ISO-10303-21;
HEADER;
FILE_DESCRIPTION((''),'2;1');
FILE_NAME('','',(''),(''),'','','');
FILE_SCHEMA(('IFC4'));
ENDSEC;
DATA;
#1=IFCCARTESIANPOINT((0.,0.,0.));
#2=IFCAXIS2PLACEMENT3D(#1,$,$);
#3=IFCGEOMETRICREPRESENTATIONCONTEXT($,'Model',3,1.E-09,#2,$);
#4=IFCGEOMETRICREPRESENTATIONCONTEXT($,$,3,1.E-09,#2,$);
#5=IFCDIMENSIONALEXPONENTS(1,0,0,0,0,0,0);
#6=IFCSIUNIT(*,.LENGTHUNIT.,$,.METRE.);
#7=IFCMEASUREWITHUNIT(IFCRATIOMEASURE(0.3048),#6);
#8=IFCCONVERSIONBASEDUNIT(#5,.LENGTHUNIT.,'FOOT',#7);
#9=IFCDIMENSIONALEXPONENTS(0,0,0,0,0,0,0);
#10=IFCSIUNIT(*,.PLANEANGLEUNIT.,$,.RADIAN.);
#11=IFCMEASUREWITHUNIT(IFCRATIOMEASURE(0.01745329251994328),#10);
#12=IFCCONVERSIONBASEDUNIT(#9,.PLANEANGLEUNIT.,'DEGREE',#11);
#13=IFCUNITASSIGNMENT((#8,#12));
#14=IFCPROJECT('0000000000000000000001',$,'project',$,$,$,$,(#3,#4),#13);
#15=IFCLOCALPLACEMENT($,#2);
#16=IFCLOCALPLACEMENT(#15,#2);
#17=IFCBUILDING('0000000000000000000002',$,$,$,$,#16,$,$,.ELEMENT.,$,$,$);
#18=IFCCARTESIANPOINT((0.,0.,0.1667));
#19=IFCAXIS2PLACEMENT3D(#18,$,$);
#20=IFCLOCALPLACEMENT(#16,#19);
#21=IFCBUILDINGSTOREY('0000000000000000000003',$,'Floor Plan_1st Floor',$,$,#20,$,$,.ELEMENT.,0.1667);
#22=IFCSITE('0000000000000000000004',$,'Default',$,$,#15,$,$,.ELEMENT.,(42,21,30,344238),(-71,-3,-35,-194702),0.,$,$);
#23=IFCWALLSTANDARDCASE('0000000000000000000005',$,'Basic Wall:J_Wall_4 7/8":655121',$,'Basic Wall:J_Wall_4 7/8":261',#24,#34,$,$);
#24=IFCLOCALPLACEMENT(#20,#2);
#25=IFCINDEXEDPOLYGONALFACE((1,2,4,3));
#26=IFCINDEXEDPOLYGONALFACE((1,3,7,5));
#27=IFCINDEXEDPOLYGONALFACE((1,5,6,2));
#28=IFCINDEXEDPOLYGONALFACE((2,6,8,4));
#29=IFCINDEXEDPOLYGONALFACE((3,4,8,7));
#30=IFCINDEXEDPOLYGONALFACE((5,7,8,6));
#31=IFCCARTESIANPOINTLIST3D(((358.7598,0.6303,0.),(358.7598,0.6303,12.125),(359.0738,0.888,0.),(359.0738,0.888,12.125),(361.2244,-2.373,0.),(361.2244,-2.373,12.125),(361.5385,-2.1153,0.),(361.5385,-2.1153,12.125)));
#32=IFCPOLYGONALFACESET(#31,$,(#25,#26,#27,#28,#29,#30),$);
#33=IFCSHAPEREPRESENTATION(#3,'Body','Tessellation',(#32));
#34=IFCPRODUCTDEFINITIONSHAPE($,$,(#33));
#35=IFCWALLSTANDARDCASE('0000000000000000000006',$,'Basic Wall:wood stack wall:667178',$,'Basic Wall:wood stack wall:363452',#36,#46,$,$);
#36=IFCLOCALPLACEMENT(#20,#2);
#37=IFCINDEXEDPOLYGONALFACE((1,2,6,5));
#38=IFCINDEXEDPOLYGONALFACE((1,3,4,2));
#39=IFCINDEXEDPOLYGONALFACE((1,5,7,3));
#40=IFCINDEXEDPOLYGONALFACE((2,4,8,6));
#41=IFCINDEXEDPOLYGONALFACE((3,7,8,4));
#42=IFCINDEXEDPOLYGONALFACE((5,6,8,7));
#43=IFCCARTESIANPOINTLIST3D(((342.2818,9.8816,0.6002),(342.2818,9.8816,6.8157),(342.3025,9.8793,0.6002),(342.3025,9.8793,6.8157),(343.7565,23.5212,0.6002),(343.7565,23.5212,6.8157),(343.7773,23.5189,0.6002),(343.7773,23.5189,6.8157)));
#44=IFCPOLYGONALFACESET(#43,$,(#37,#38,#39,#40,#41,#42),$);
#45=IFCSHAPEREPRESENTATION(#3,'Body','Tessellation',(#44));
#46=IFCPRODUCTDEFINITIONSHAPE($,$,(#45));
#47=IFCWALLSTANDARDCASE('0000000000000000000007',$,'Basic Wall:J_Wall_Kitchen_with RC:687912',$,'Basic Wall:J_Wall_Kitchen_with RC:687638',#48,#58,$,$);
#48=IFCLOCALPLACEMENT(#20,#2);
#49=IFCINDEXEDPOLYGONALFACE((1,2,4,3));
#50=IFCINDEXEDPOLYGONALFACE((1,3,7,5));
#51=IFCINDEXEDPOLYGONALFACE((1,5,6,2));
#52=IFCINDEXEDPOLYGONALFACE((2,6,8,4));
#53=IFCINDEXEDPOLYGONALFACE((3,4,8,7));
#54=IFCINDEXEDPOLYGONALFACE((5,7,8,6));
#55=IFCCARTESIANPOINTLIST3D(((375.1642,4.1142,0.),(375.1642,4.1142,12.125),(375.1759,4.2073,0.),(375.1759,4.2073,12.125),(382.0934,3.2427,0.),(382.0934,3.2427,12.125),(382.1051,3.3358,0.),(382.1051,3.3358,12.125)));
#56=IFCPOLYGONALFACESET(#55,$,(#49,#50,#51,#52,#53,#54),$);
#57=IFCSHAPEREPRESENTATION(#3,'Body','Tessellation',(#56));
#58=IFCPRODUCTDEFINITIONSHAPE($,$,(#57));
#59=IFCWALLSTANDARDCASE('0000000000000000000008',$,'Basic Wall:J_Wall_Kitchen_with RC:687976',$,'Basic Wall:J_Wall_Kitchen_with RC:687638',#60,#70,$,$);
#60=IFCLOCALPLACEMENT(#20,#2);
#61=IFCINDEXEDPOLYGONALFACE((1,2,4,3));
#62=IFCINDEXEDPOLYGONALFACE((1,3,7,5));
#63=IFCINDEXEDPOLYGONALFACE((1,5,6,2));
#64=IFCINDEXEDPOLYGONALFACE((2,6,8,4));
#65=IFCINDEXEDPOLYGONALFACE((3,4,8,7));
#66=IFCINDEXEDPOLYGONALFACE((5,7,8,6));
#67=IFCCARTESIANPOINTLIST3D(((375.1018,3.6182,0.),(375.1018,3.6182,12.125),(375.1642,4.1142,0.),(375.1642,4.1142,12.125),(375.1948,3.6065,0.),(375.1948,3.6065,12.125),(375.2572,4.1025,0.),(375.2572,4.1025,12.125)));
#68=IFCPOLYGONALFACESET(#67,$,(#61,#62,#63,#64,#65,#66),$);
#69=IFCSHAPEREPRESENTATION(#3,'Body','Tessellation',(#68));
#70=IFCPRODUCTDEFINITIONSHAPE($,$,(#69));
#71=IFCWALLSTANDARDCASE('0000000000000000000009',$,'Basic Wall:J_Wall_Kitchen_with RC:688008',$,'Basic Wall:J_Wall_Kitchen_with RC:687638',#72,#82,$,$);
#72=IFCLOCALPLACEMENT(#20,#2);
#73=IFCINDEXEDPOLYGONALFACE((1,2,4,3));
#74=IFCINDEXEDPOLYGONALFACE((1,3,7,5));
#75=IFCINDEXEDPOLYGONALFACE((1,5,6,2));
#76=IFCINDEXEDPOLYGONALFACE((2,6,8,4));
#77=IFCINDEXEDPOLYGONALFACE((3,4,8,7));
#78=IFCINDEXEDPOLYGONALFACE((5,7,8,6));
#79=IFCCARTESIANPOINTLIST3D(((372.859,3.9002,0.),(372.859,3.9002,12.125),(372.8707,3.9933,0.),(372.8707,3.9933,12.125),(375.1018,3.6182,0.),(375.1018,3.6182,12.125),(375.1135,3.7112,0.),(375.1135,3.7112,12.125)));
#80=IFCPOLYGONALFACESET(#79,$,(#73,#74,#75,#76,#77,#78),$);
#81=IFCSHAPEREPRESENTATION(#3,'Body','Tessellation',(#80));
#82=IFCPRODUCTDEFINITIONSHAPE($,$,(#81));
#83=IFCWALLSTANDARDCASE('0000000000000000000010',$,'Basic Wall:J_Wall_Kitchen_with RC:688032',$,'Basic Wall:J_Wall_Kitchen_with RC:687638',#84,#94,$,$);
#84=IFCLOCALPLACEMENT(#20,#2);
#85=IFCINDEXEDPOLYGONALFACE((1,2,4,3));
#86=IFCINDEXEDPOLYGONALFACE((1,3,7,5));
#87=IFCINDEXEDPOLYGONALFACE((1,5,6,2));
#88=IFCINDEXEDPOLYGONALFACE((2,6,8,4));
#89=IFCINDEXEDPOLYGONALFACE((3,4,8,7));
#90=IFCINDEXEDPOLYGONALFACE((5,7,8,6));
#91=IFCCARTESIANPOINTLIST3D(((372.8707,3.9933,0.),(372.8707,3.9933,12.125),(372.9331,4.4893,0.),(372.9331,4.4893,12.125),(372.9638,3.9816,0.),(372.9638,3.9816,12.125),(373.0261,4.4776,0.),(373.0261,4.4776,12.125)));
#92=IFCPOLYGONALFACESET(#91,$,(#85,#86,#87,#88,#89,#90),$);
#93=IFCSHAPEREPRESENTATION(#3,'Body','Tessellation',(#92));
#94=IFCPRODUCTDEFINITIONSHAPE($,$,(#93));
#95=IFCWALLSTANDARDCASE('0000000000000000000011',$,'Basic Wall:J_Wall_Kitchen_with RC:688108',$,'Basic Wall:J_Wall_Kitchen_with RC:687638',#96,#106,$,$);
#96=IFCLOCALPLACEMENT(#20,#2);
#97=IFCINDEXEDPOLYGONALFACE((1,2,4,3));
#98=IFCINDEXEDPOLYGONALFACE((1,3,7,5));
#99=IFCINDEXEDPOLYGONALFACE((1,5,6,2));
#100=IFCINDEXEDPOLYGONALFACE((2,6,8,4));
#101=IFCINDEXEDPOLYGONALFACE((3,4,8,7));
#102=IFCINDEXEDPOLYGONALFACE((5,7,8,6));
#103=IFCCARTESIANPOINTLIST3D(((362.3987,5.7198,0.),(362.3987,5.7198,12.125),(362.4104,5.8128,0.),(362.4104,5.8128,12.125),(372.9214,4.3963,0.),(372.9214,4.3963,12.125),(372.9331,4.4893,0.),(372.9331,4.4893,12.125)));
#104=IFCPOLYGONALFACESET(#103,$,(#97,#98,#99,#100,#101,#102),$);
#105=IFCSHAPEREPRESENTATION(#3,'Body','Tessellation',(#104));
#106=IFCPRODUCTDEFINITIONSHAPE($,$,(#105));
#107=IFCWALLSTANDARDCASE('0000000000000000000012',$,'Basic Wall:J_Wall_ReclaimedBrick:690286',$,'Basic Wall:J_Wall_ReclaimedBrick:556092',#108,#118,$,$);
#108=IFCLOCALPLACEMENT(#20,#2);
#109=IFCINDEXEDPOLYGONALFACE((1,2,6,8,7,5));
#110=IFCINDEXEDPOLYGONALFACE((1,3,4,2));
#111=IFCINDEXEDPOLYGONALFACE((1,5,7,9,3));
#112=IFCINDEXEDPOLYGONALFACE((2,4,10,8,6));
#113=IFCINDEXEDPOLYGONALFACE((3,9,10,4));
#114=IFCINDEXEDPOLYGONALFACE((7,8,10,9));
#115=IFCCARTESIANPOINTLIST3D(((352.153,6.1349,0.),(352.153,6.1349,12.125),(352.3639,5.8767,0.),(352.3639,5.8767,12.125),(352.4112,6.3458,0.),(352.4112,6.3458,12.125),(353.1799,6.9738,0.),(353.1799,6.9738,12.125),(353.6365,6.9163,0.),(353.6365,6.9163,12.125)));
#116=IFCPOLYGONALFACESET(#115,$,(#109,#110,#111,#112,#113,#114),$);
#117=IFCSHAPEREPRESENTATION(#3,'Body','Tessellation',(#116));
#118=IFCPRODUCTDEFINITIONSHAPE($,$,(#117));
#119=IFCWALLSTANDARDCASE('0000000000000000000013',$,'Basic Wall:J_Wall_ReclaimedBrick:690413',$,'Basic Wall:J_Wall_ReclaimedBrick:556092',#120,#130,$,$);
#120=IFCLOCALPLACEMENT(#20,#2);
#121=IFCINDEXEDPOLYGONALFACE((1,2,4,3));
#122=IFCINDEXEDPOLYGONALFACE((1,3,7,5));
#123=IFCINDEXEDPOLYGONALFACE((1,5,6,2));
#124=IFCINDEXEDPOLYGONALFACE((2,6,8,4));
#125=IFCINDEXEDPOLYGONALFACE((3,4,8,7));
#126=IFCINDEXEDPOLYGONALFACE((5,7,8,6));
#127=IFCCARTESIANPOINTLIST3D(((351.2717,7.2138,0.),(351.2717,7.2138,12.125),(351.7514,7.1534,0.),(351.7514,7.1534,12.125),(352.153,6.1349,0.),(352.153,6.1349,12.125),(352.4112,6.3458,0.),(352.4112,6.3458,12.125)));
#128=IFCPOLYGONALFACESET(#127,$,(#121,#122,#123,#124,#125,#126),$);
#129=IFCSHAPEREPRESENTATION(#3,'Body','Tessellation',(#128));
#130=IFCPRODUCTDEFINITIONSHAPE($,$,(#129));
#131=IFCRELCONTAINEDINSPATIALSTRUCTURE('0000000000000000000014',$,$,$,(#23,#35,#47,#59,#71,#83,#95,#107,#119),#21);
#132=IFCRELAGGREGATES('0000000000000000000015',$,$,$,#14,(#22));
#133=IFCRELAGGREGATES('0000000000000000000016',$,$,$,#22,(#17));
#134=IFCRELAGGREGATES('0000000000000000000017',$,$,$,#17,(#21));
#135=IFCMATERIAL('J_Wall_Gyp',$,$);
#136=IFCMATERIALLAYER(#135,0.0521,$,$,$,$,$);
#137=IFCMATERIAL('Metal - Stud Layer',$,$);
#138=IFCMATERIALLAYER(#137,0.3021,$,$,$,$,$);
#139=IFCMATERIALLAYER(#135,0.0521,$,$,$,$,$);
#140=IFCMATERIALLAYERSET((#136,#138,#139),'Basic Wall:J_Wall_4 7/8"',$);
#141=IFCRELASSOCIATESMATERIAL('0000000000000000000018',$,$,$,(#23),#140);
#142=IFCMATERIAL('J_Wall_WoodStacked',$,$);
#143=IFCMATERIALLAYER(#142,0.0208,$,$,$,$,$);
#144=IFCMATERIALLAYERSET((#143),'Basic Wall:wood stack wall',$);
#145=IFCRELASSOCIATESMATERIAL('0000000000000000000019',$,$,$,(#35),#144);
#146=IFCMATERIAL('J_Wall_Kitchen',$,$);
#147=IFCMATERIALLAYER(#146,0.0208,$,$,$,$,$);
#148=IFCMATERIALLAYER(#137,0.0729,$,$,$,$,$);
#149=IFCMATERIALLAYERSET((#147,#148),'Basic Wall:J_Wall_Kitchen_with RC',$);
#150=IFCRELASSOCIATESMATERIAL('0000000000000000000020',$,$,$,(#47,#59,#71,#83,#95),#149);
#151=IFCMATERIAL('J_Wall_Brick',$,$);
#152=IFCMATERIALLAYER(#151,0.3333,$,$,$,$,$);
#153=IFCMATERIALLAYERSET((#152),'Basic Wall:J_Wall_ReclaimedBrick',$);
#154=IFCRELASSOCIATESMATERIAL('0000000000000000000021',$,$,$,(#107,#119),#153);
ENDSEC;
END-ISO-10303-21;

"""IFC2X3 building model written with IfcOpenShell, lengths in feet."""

from ifc_helpers import new_model, entity, si_unit, converted_unit, frame, frame_2d, origin, place, context, project, spatial, polyline, rectangle, outline, extrude, clip, halfspace, material, layer, layer_set, layer_usage, element, save


model = new_model("IFC2X3")

# Units and contexts
model_context = context("Model", 3, precision=1e-09, world=origin())
context_of_model = context(None, 3, precision=1e-09, world=origin())
ifc_project = project(units=[converted_unit("LENGTHUNIT", "FOOT", entity("IfcRatioMeasure", 0.3048), si_unit("LENGTHUNIT", "METRE"), dimensions=[1, 0, 0, 0, 0, 0, 0]), converted_unit("PLANEANGLEUNIT", "DEGREE", entity("IfcRatioMeasure", 0.01745329251994328), si_unit("PLANEANGLEUNIT", "RADIAN"), dimensions=[0, 0, 0, 0, 0, 0, 0])], contexts=[model_context, context_of_model])

# Site, building, storey
site_placement = place(None, origin())
site = spatial("IfcSite", under=ifc_project, at=site_placement, Name="Default", CompositionType="ELEMENT", RefLatitude=(42, 21, 30, 344238), RefLongitude=(-71, -3, -35, -194702), RefElevation=0.0)
building_placement = place(site_placement, origin())
building = spatial("IfcBuilding", under=site, at=building_placement, CompositionType="ELEMENT")
storey_placement = place(building_placement, frame((0.0, 0.0, 0.1667)))
storey = spatial("IfcBuildingStorey", under=building, at=storey_placement, Name="Floor Plan_1st Floor", CompositionType="ELEMENT", Elevation=0.1667)

# Shared definitions
ifc_material_1 = material(Name="J_Wall_Brick")
ifc_material_2 = material(Name="J_Wall_Gyp")
ifc_layer_1 = layer(ifc_material_2, 0.0521)
ifc_material_3 = material(Name="Metal - Stud Layer")
ifc_layer_2 = layer(ifc_material_3, 0.3021)
ifc_layer_3 = layer(ifc_material_2, 0.0521)
ifc_layer_set_1 = layer_set([ifc_layer_1, ifc_layer_2, ifc_layer_3], Name="Basic Wall:J_Wall_4 7/8\"")

# Walls
ifc_layer_usage_1 = layer_usage(ifc_layer_set_1, "AXIS2", "POSITIVE", -0.2031)
wall_1_placement = place(storey_placement, frame((358.9168, 0.7591, 0.0), z_axis=(0.0, 0.0, 1.0), x_axis=(0.63438, -0.773021, 0.0)))
element("IfcWallStandardCase", 1, at=wall_1_placement, inside=storey, material=ifc_layer_usage_1, Name="Basic Wall:J_Wall_4 7/8\":655121", ObjectType="Basic Wall:J_Wall_4 7/8\":261", context=model_context, shape_type="SweptSolid", body=[
    extrude(rectangle(XDim=3.8851, YDim=0.4063, at=frame_2d((1.9426, 0.0), x_axis=(-1.0, 0.0))), origin(), (0.0, 0.0, 1.0), 12.125),
])
ifc_material_4 = material(Name="J_Wall_WoodStacked")
ifc_layer_4 = layer(ifc_material_4, 0.0208)
ifc_layer_set_2 = layer_set([ifc_layer_4], Name="Basic Wall:wood stack wall")
ifc_layer_usage_2 = layer_usage(ifc_layer_set_2, "AXIS2", "POSITIVE", -0.0104)
wall_2_placement = place(storey_placement, frame((343.7669, 23.5201, 0.6002), z_axis=(0.0, 0.0, 1.0), x_axis=(-0.107495, -0.994206, 0.0)))
element("IfcWallStandardCase", 2, at=wall_2_placement, inside=storey, material=ifc_layer_usage_2, Name="Basic Wall:wood stack wall:667178", ObjectType="Basic Wall:wood stack wall:363452", context=model_context, shape_type="SweptSolid", body=[
    extrude(rectangle(XDim=13.7191, YDim=0.0208, at=frame_2d((6.8595, 0.0), x_axis=(-1.0, 0.0))), origin(), (0.0, 0.0, 1.0), 6.2154),
])
ifc_material_5 = material(Name="J_Wall_Kitchen")
ifc_layer_5 = layer(ifc_material_5, 0.0208)
ifc_layer_6 = layer(ifc_material_3, 0.0729)
ifc_layer_set_3 = layer_set([ifc_layer_5, ifc_layer_6], Name="Basic Wall:J_Wall_Kitchen_with RC")
ifc_layer_usage_3 = layer_usage(ifc_layer_set_3, "AXIS2", "NEGATIVE", 0.0469)
wall_3_placement = place(storey_placement, frame((382.0993, 3.2892, 0.0), z_axis=(0.0, 0.0, 1.0), x_axis=(-0.992183, 0.12479, 0.0)))
element("IfcWallStandardCase", 3, at=wall_3_placement, inside=storey, material=ifc_layer_usage_3, Name="Basic Wall:J_Wall_Kitchen_with RC:687912", ObjectType="Basic Wall:J_Wall_Kitchen_with RC:687638", context=model_context, shape_type="Clipping", body=[
    clip(extrude(rectangle(XDim=6.9838, YDim=0.0938, at=frame_2d((3.4919, 0.0), x_axis=(-1.0, 0.0))), origin(), (0.0, 0.0, 1.0), 12.125), halfspace(origin(), True)),
])
ifc_layer_usage_4 = layer_usage(ifc_layer_set_3, "AXIS2", "NEGATIVE", 0.0469)
wall_4_placement = place(storey_placement, frame((375.2107, 4.1084, 0.0), z_axis=(0.0, 0.0, 1.0), x_axis=(-0.12479, -0.992183, 0.0)))
element("IfcWallStandardCase", 4, at=wall_4_placement, inside=storey, material=ifc_layer_usage_4, Name="Basic Wall:J_Wall_Kitchen_with RC:687976", ObjectType="Basic Wall:J_Wall_Kitchen_with RC:687638", context=model_context, shape_type="Clipping", body=[
    clip(extrude(rectangle(XDim=0.5, YDim=0.0938, at=frame_2d((0.25, 0.0), x_axis=(-1.0, 0.0))), origin(), (0.0, 0.0, 1.0), 12.125), halfspace(origin(), True)),
])
ifc_layer_usage_5 = layer_usage(ifc_layer_set_3, "AXIS2", "NEGATIVE", 0.0469)
wall_5_placement = place(storey_placement, frame((375.1076, 3.6647, 0.0), z_axis=(0.0, 0.0, 1.0), x_axis=(-0.992183, 0.12479, 0.0)))
element("IfcWallStandardCase", 5, at=wall_5_placement, inside=storey, material=ifc_layer_usage_5, Name="Basic Wall:J_Wall_Kitchen_with RC:688008", ObjectType="Basic Wall:J_Wall_Kitchen_with RC:687638", context=model_context, shape_type="Clipping", body=[
    clip(extrude(rectangle(XDim=2.2604, YDim=0.0938, at=frame_2d((1.1302, 0.0), x_axis=(-1.0, 0.0))), origin(), (0.0, 0.0, 1.0), 12.125), halfspace(origin(), True)),
])
ifc_layer_usage_6 = layer_usage(ifc_layer_set_3, "AXIS2", "NEGATIVE", 0.0469)
wall_6_placement = place(storey_placement, frame((372.9172, 3.9874, 0.0), z_axis=(0.0, 0.0, 1.0), x_axis=(0.12479, 0.992183, 0.0)))
element("IfcWallStandardCase", 6, at=wall_6_placement, inside=storey, material=ifc_layer_usage_6, Name="Basic Wall:J_Wall_Kitchen_with RC:688032", ObjectType="Basic Wall:J_Wall_Kitchen_with RC:687638", context=model_context, shape_type="Clipping", body=[
    clip(extrude(rectangle(XDim=0.5, YDim=0.0938, at=frame_2d((0.25, 0.0), x_axis=(-1.0, 0.0))), origin(), (0.0, 0.0, 1.0), 12.125), halfspace(origin(), True)),
])
ifc_layer_usage_7 = layer_usage(ifc_layer_set_3, "AXIS2", "NEGATIVE", 0.0469)
wall_7_placement = place(storey_placement, frame((372.9273, 4.4428, 0.0), z_axis=(0.0, 0.0, 1.0), x_axis=(-0.992183, 0.12479, 0.0)))
element("IfcWallStandardCase", 7, at=wall_7_placement, inside=storey, material=ifc_layer_usage_7, Name="Basic Wall:J_Wall_Kitchen_with RC:688108", ObjectType="Basic Wall:J_Wall_Kitchen_with RC:687638", context=model_context, shape_type="Clipping", body=[
    clip(extrude(rectangle(XDim=10.6056, YDim=0.0938, at=frame_2d((5.3028, 0.0), x_axis=(-1.0, 0.0))), origin(), (0.0, 0.0, 1.0), 12.125), halfspace(origin(), True)),
])
ifc_layer_7 = layer(ifc_material_1, 0.3333)
ifc_layer_set_4 = layer_set([ifc_layer_7], Name="Basic Wall:J_Wall_ReclaimedBrick")
ifc_layer_usage_8 = layer_usage(ifc_layer_set_4, "AXIS2", "POSITIVE", -0.1667)
wall_8_placement = place(storey_placement, frame((352.2585, 6.0058, 0.0), z_axis=(0.0, 0.0, 1.0), x_axis=(0.774444, 0.632643, 0.0)))
element("IfcWallStandardCase", 8, at=wall_8_placement, inside=storey, material=ifc_layer_usage_8, Name="Basic Wall:J_Wall_ReclaimedBrick:690286", ObjectType="Basic Wall:J_Wall_ReclaimedBrick:556092", context=model_context, shape_type="SweptSolid", body=[
    extrude(outline(polyline([(1.6433, -0.1667), (1.326, 0.1667), (0.3333, 0.1667), (0.0, 0.1667), (0.0, -0.1667), (1.6433, -0.1667)])), origin(), (0.0, 0.0, 1.0), 12.125),
])
ifc_layer_usage_9 = layer_usage(ifc_layer_set_4, "AXIS2", "NEGATIVE", 0.1667)
wall_9_placement = place(storey_placement, frame((352.2821, 6.2403, 0.0), z_axis=(0.0, 0.0, 1.0), x_axis=(-0.632643, 0.774444, 0.0)))
element("IfcWallStandardCase", 9, at=wall_9_placement, inside=storey, material=ifc_layer_usage_9, Name="Basic Wall:J_Wall_ReclaimedBrick:690413", ObjectType="Basic Wall:J_Wall_ReclaimedBrick:556092", context=model_context, shape_type="SweptSolid", body=[
    extrude(outline(polyline([(1.0429, -0.1667), (1.3931, 0.1667), (0.0, 0.1667), (0.0, -0.1667), (1.0429, -0.1667)])), origin(), (0.0, 0.0, 1.0), 12.125),
])

save(model, "model.ifc")
